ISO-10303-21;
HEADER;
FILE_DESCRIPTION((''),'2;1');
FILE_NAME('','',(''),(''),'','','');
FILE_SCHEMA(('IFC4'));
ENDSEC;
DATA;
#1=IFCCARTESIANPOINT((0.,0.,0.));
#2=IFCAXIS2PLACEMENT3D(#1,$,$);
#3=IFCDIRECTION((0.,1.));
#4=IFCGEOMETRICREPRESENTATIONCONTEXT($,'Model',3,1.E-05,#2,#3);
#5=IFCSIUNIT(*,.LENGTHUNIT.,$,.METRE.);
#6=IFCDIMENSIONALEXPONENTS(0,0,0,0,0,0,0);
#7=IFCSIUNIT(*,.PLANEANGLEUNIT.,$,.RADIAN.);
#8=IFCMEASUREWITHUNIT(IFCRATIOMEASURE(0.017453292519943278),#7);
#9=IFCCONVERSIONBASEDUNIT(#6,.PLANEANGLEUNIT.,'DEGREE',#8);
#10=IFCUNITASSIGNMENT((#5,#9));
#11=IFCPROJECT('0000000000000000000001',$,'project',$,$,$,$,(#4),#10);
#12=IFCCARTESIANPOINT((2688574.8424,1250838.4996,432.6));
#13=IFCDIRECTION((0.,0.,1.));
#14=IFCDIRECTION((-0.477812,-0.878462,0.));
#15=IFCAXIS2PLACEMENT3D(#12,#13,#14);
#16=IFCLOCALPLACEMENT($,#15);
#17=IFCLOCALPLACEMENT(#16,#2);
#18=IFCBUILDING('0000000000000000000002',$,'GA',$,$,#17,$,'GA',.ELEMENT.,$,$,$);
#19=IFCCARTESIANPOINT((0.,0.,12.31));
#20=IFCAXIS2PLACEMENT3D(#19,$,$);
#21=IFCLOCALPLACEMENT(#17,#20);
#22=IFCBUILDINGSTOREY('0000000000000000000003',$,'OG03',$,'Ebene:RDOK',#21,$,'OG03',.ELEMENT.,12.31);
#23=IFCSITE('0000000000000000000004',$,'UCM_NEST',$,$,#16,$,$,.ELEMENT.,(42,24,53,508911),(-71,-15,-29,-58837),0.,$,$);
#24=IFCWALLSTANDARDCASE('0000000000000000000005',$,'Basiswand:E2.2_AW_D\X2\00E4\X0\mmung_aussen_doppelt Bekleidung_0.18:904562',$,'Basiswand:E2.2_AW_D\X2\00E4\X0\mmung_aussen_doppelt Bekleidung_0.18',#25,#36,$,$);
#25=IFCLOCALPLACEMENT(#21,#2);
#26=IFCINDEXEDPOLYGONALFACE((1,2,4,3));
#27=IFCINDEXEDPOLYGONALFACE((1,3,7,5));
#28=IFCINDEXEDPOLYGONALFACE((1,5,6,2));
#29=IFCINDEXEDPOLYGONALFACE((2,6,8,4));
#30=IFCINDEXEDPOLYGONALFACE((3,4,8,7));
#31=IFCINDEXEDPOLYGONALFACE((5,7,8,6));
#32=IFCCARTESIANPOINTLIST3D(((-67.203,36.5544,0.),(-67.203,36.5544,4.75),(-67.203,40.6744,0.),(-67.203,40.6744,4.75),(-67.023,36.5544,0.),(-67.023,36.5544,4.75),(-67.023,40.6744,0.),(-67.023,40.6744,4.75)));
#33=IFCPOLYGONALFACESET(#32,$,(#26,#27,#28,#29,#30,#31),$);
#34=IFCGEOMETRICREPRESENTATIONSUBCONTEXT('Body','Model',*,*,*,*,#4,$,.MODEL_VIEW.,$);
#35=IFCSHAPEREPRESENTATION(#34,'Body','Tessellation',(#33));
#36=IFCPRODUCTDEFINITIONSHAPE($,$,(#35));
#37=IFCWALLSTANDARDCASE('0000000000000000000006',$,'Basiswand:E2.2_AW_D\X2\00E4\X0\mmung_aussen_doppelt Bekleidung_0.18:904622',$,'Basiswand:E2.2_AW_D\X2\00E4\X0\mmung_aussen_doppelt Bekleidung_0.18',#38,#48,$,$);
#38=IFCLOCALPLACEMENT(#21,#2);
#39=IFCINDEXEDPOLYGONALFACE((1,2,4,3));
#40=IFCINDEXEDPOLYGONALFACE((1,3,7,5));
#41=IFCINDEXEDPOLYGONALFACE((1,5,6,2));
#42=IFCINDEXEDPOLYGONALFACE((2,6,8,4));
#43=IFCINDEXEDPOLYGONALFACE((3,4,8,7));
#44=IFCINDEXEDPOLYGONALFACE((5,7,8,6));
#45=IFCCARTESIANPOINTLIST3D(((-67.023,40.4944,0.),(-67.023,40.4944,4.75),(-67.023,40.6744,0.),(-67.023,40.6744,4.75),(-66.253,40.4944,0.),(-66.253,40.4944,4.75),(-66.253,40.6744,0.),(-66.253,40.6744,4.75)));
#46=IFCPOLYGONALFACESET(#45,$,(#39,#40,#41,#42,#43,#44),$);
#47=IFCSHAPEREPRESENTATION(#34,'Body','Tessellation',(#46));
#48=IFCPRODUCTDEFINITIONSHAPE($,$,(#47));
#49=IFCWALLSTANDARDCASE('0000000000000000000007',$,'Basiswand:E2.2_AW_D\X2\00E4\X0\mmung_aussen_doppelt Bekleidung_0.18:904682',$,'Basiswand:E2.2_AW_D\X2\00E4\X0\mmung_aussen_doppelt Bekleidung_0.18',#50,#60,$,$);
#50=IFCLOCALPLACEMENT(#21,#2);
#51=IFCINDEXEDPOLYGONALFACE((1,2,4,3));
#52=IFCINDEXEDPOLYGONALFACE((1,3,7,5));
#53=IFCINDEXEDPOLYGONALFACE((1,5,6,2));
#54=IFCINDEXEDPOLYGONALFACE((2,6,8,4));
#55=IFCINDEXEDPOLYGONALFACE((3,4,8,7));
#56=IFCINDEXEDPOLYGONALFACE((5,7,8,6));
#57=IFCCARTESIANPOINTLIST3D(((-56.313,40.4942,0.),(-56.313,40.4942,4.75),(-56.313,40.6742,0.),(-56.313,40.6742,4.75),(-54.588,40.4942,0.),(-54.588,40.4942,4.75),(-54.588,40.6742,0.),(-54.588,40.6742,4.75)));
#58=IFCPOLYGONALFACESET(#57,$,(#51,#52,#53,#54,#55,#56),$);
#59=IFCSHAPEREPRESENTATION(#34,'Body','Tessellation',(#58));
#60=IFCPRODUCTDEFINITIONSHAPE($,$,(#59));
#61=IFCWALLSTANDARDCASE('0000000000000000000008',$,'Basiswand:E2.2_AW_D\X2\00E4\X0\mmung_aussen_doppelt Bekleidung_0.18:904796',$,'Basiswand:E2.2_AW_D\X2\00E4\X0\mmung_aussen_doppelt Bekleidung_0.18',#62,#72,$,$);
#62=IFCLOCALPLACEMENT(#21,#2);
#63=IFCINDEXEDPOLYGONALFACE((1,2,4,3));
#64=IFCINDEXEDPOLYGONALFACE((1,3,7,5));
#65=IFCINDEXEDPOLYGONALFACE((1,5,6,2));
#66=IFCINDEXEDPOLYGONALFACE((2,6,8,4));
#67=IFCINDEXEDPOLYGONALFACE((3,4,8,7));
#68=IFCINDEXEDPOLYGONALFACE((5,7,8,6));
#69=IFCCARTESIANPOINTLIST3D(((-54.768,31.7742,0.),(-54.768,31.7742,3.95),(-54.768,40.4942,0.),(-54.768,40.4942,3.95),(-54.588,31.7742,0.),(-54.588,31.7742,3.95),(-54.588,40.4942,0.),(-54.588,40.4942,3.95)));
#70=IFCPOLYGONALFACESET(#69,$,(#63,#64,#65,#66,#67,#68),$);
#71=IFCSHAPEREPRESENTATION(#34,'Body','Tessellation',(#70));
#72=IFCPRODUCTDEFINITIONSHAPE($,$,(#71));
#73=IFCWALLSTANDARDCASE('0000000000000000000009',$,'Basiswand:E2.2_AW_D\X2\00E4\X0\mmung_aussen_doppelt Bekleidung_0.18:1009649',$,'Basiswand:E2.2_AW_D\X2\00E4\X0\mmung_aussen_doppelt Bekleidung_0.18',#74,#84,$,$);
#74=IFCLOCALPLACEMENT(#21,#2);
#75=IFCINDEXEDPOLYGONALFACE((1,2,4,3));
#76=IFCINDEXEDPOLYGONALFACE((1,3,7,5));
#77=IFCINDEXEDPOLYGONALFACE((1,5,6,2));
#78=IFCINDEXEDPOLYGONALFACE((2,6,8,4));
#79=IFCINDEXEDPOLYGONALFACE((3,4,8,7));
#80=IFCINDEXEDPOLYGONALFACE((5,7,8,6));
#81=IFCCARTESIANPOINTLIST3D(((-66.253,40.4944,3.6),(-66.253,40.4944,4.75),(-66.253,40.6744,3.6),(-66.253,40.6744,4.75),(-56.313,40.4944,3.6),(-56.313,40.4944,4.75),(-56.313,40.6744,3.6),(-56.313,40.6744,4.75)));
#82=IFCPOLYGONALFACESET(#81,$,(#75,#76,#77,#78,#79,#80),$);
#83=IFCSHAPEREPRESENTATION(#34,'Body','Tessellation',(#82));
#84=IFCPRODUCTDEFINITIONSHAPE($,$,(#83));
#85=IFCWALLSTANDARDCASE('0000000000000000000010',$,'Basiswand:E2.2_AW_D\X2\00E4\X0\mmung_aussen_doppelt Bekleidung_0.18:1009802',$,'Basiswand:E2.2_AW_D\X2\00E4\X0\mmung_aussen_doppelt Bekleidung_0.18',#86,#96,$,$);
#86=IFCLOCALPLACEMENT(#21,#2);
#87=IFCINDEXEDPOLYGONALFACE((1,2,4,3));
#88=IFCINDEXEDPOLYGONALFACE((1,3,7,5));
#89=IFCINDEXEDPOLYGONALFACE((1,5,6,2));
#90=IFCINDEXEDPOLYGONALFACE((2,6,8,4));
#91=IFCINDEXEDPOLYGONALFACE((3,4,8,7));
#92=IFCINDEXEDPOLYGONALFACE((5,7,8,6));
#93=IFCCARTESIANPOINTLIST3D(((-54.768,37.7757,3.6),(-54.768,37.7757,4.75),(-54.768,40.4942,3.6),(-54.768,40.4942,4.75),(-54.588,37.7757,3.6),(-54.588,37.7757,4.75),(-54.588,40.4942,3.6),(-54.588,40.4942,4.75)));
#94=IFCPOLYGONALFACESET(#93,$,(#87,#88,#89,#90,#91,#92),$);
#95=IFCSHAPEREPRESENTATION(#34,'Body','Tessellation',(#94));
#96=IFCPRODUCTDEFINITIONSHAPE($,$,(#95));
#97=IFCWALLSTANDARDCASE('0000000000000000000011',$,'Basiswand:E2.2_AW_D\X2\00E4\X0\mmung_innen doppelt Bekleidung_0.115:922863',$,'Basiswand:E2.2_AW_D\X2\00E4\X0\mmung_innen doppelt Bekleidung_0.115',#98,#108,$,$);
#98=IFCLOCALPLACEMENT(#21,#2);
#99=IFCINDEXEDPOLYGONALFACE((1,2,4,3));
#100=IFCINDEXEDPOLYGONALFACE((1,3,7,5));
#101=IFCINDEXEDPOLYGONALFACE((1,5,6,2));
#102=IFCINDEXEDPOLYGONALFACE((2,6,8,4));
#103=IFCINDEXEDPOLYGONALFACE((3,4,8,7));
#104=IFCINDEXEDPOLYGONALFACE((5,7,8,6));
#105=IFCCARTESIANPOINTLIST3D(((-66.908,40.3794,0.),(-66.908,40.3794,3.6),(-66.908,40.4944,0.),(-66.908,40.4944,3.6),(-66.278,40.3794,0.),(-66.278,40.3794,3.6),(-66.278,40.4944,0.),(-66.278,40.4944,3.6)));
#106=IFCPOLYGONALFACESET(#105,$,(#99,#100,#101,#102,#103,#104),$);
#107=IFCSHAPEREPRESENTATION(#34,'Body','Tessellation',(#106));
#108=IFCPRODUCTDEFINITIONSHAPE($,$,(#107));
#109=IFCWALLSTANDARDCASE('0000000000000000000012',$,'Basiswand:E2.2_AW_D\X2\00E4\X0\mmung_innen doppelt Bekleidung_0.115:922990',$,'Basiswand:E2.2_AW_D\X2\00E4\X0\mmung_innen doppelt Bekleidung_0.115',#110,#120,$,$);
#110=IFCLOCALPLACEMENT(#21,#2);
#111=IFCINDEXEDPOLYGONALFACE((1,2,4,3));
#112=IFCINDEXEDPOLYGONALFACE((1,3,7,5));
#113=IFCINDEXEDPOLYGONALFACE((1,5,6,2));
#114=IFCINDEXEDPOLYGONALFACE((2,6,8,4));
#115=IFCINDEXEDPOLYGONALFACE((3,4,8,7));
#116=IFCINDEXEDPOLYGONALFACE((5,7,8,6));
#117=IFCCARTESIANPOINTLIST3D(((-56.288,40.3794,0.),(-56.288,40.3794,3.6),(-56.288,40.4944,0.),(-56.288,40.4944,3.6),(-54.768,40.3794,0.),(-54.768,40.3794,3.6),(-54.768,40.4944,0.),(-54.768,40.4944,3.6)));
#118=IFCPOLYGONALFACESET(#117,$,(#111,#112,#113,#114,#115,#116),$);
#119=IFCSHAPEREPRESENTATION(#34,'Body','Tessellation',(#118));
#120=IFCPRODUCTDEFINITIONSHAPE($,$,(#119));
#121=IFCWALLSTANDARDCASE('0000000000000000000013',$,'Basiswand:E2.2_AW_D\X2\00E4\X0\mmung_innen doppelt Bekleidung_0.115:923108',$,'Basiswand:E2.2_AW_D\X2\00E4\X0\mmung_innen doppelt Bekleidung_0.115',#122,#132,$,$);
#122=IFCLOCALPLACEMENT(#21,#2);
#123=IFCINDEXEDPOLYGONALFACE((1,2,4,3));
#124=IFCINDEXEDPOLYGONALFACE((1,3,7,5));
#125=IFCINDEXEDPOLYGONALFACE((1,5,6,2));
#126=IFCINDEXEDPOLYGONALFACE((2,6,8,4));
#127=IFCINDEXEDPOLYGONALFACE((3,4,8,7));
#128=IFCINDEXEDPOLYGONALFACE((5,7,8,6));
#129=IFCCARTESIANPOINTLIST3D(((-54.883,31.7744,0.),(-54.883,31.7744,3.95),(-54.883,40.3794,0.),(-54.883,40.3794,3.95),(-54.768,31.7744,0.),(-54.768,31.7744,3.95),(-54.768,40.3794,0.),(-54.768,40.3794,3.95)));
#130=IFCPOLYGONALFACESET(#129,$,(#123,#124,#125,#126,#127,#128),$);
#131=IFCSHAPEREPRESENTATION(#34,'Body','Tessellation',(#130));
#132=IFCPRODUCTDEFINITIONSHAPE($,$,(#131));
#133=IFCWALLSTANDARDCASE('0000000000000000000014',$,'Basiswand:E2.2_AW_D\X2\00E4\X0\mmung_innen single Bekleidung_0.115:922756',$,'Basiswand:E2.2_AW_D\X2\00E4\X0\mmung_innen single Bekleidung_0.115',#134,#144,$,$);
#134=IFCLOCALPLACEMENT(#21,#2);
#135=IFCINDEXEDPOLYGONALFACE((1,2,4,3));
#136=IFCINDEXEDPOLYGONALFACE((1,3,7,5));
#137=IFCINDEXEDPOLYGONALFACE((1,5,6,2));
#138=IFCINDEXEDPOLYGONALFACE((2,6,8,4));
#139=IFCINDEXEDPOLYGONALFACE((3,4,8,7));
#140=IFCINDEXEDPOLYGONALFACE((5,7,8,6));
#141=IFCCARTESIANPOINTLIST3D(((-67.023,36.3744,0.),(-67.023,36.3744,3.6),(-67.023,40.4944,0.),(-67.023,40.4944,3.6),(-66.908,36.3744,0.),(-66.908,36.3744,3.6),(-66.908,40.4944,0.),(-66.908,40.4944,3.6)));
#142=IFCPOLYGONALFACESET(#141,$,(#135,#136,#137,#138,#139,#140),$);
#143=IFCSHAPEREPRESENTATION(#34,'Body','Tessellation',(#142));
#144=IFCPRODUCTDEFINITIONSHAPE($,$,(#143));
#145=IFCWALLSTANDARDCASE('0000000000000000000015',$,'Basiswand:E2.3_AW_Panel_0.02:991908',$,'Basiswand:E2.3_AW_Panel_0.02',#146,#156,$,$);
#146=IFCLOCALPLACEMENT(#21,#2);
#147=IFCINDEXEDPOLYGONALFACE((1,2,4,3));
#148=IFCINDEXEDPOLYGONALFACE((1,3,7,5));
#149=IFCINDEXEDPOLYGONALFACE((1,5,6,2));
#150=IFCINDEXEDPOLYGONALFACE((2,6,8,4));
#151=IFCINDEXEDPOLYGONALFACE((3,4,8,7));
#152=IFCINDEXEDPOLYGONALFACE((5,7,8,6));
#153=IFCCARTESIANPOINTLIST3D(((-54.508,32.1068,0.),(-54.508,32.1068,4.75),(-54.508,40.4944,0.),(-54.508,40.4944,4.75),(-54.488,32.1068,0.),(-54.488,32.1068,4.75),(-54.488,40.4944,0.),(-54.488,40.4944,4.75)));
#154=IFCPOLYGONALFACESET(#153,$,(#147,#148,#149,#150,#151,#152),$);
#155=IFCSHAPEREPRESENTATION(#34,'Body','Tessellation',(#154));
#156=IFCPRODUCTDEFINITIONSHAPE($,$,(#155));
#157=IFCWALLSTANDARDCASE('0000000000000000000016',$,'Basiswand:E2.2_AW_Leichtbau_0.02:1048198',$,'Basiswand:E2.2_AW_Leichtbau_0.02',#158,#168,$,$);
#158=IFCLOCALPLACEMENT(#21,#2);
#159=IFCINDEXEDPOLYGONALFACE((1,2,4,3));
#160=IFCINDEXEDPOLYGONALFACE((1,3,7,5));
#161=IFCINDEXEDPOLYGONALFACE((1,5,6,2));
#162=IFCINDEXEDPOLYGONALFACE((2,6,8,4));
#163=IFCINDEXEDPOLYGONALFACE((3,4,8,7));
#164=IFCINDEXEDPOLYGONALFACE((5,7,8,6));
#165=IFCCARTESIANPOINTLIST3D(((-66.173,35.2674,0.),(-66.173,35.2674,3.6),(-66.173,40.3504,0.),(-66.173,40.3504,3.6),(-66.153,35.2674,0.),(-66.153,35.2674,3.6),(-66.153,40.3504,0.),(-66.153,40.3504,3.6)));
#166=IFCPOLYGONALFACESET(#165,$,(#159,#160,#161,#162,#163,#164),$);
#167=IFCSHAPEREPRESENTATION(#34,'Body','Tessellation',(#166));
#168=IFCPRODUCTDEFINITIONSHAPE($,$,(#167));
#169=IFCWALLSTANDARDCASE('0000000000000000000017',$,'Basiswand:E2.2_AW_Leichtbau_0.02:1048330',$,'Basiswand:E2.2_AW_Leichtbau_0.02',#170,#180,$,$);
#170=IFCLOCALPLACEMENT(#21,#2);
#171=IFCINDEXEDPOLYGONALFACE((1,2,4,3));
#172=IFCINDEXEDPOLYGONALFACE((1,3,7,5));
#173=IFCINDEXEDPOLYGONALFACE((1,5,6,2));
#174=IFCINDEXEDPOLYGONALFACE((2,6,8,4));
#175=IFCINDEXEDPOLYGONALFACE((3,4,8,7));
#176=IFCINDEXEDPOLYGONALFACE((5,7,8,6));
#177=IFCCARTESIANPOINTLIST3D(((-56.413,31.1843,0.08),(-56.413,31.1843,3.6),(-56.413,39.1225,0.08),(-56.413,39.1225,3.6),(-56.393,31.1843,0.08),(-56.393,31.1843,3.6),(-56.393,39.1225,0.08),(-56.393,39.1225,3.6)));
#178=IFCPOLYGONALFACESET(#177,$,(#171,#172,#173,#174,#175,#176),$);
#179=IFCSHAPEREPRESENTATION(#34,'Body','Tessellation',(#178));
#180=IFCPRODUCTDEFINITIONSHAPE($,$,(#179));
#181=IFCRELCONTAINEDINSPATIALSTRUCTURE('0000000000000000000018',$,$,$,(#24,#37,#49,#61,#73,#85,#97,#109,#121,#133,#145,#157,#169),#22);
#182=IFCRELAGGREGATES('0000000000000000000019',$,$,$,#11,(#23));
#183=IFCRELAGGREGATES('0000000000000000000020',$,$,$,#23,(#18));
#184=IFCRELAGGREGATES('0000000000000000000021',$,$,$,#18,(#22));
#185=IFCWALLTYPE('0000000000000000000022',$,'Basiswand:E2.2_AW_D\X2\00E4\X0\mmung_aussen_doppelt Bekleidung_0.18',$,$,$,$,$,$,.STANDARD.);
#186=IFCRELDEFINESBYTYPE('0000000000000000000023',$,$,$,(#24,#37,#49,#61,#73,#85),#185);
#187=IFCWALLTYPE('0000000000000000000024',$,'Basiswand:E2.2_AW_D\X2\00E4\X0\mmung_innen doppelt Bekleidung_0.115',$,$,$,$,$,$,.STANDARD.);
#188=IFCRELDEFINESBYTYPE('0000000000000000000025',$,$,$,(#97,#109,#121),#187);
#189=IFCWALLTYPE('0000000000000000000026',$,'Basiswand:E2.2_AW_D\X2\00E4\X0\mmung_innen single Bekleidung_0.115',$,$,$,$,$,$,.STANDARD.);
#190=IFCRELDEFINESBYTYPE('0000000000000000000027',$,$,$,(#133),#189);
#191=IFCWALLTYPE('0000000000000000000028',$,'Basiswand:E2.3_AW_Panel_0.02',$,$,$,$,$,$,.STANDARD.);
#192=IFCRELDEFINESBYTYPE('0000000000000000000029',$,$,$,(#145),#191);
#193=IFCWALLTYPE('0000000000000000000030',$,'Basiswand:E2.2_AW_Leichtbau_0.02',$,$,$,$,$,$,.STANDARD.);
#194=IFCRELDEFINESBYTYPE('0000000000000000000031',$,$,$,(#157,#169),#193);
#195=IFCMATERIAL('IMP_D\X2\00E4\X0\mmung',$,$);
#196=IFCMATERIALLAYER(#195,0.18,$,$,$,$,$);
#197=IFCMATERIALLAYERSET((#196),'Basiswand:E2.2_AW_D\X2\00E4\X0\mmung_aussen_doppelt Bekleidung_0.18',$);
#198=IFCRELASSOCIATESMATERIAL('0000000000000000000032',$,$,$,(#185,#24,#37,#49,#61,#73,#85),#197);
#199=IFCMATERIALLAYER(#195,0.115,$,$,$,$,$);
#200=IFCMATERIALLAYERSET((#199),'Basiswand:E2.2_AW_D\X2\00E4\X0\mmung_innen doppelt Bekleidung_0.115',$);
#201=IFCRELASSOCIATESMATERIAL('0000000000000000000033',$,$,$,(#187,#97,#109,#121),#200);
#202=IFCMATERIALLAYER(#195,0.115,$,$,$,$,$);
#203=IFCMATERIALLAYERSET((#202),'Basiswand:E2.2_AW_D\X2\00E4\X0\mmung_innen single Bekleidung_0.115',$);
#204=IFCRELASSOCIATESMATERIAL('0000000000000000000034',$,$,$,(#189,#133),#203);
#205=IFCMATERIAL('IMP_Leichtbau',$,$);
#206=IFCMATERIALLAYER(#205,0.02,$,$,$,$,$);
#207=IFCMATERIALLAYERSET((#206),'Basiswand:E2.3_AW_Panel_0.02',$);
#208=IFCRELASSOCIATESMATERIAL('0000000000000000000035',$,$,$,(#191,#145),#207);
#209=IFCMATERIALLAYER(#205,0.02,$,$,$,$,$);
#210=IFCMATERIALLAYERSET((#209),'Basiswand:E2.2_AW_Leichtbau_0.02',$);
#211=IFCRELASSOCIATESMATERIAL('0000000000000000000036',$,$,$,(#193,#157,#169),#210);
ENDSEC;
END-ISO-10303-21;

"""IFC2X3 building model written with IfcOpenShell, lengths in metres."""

from ifc_helpers import new_model, entity, si_unit, converted_unit, direction, frame, frame_2d, origin, place, context, subcontext, project, spatial, polyline, rectangle, extrude, clip, bounded_halfspace, material, layer, layer_set, layer_usage, type_object, element, save


model = new_model("IFC2X3")

# Units and contexts
model_context = context("Model", 3, precision=1e-05, world=origin(), true_north=direction((0.0, 1.0)))
body_context = subcontext(model_context, "Body", "Model", "MODEL_VIEW")
ifc_project = project(units=[si_unit("LENGTHUNIT", "METRE"), converted_unit("PLANEANGLEUNIT", "DEGREE", entity("IfcRatioMeasure", 0.017453292519943278), si_unit("PLANEANGLEUNIT", "RADIAN"), dimensions=[0, 0, 0, 0, 0, 0, 0])], contexts=[model_context])

# Site, building, storey
site_placement = place(None, frame((2688574.8424, 1250838.4996, 432.6), z_axis=(0.0, 0.0, 1.0), x_axis=(-0.477812, -0.878462, 0.0)))
site = spatial("IfcSite", under=ifc_project, at=site_placement, Name="UCM_NEST", CompositionType="ELEMENT", RefLatitude=(42, 24, 53, 508911), RefLongitude=(-71, -15, -29, -58837), RefElevation=0.0)
building_placement = place(site_placement, origin())
building = spatial("IfcBuilding", under=site, at=building_placement, Name="GA", LongName="GA", CompositionType="ELEMENT")
storey_placement = place(building_placement, frame((0.0, 0.0, 12.31)))
storey = spatial("IfcBuildingStorey", under=building, at=storey_placement, Name="OG03", ObjectType="Ebene:RDOK", LongName="OG03", CompositionType="ELEMENT", Elevation=12.31)

# Walls
ifc_material_1 = material(Name="IMP_Dämmung")
ifc_layer_1 = layer(ifc_material_1, 0.18)
ifc_layer_set_1 = layer_set([ifc_layer_1], Name="Basiswand:E2.2_AW_Dämmung_aussen_doppelt Bekleidung_0.18")
ifc_layer_usage_1 = layer_usage(ifc_layer_set_1, "AXIS2", "NEGATIVE", 0.09)
wall_type_1 = type_object("IfcWallType", Name="Basiswand:E2.2_AW_Dämmung_aussen_doppelt Bekleidung_0.18", PredefinedType="STANDARD", material=ifc_layer_set_1)
wall_1_placement = place(storey_placement, frame((-67.113, 36.5544, 0.0), z_axis=(0.0, 0.0, 1.0), x_axis=(0.0, 1.0, 0.0)))
element("IfcWallStandardCase", 1, at=wall_1_placement, inside=storey, type_object=wall_type_1, material=ifc_layer_usage_1, Name="Basiswand:E2.2_AW_Dämmung_aussen_doppelt Bekleidung_0.18:904562", ObjectType="Basiswand:E2.2_AW_Dämmung_aussen_doppelt Bekleidung_0.18", context=body_context, shape_type="SweptSolid", body=[
    extrude(rectangle(XDim=4.12, YDim=0.18, at=frame_2d((2.06, 0.0), x_axis=(-1.0, 0.0))), origin(), (0.0, 0.0, 1.0), 4.75),
])
wall_2_placement = place(storey_placement, frame((-67.023, 40.5844, 0.0)))
element("IfcWallStandardCase", 2, at=wall_2_placement, inside=storey, type_object=wall_type_1, material=ifc_layer_usage_1, Name="Basiswand:E2.2_AW_Dämmung_aussen_doppelt Bekleidung_0.18:904622", ObjectType="Basiswand:E2.2_AW_Dämmung_aussen_doppelt Bekleidung_0.18", context=body_context, shape_type="SweptSolid", body=[
    extrude(rectangle(XDim=0.77, YDim=0.18, at=frame_2d((0.385, 0.0), x_axis=(-1.0, 0.0))), origin(), (0.0, 0.0, 1.0), 4.75),
])
wall_3_placement = place(storey_placement, frame((-56.313, 40.5842, 0.0)))
element("IfcWallStandardCase", 3, at=wall_3_placement, inside=storey, type_object=wall_type_1, material=ifc_layer_usage_1, Name="Basiswand:E2.2_AW_Dämmung_aussen_doppelt Bekleidung_0.18:904682", ObjectType="Basiswand:E2.2_AW_Dämmung_aussen_doppelt Bekleidung_0.18", context=body_context, shape_type="SweptSolid", body=[
    extrude(rectangle(XDim=1.725, YDim=0.18, at=frame_2d((0.8625, 0.0), x_axis=(-1.0, 0.0))), origin(), (0.0, 0.0, 1.0), 4.75),
])
wall_4_placement = place(storey_placement, frame((-54.678, 40.4942, 0.0), z_axis=(0.0, 0.0, 1.0), x_axis=(0.0, -1.0, 0.0)))
element("IfcWallStandardCase", 4, at=wall_4_placement, inside=storey, type_object=wall_type_1, material=ifc_layer_usage_1, Name="Basiswand:E2.2_AW_Dämmung_aussen_doppelt Bekleidung_0.18:904796", ObjectType="Basiswand:E2.2_AW_Dämmung_aussen_doppelt Bekleidung_0.18", context=body_context, shape_type="SweptSolid", body=[
    extrude(rectangle(XDim=8.72, YDim=0.18, at=frame_2d((4.36, 0.0), x_axis=(-1.0, 0.0))), origin(), (0.0, 0.0, 1.0), 3.95),
])
wall_5_placement = place(storey_placement, frame((-66.253, 40.5844, 3.6)))
element("IfcWallStandardCase", 5, at=wall_5_placement, inside=storey, type_object=wall_type_1, material=ifc_layer_usage_1, Name="Basiswand:E2.2_AW_Dämmung_aussen_doppelt Bekleidung_0.18:1009649", ObjectType="Basiswand:E2.2_AW_Dämmung_aussen_doppelt Bekleidung_0.18", context=body_context, shape_type="SweptSolid", body=[
    extrude(rectangle(XDim=9.94, YDim=0.18, at=frame_2d((4.97, 0.0), x_axis=(-1.0, 0.0))), origin(), (0.0, 0.0, 1.0), 1.15),
])
wall_6_placement = place(storey_placement, frame((-54.678, 37.7757, 3.6), z_axis=(0.0, 0.0, 1.0), x_axis=(0.0, 1.0, 0.0)))
element("IfcWallStandardCase", 6, at=wall_6_placement, inside=storey, type_object=wall_type_1, material=ifc_layer_usage_1, Name="Basiswand:E2.2_AW_Dämmung_aussen_doppelt Bekleidung_0.18:1009802", ObjectType="Basiswand:E2.2_AW_Dämmung_aussen_doppelt Bekleidung_0.18", context=body_context, shape_type="SweptSolid", body=[
    extrude(rectangle(XDim=2.7185, YDim=0.18, at=frame_2d((1.3592, 0.0), x_axis=(-1.0, 0.0))), origin(), (0.0, 0.0, 1.0), 1.15),
])
ifc_layer_2 = layer(ifc_material_1, 0.115)
ifc_layer_set_2 = layer_set([ifc_layer_2], Name="Basiswand:E2.2_AW_Dämmung_innen doppelt Bekleidung_0.115")
ifc_layer_usage_2 = layer_usage(ifc_layer_set_2, "AXIS2", "NEGATIVE", 0.0575)
wall_type_2 = type_object("IfcWallType", Name="Basiswand:E2.2_AW_Dämmung_innen doppelt Bekleidung_0.115", PredefinedType="STANDARD", material=ifc_layer_set_2)
wall_7_placement = place(storey_placement, frame((-66.908, 40.4369, 0.0)))
element("IfcWallStandardCase", 7, at=wall_7_placement, inside=storey, type_object=wall_type_2, material=ifc_layer_usage_2, Name="Basiswand:E2.2_AW_Dämmung_innen doppelt Bekleidung_0.115:922863", ObjectType="Basiswand:E2.2_AW_Dämmung_innen doppelt Bekleidung_0.115", context=body_context, shape_type="SweptSolid", body=[
    extrude(rectangle(XDim=0.63, YDim=0.115, at=frame_2d((0.315, 0.0), x_axis=(-1.0, 0.0))), origin(), (0.0, 0.0, 1.0), 3.6),
])
wall_8_placement = place(storey_placement, frame((-56.288, 40.4369, 0.0)))
element("IfcWallStandardCase", 8, at=wall_8_placement, inside=storey, type_object=wall_type_2, material=ifc_layer_usage_2, Name="Basiswand:E2.2_AW_Dämmung_innen doppelt Bekleidung_0.115:922990", ObjectType="Basiswand:E2.2_AW_Dämmung_innen doppelt Bekleidung_0.115", context=body_context, shape_type="SweptSolid", body=[
    extrude(rectangle(XDim=1.52, YDim=0.115, at=frame_2d((0.76, 0.0), x_axis=(-1.0, 0.0))), origin(), (0.0, 0.0, 1.0), 3.6),
])
wall_9_placement = place(storey_placement, frame((-54.8255, 40.3794, 0.0), z_axis=(0.0, 0.0, 1.0), x_axis=(0.0, -1.0, 0.0)))
element("IfcWallStandardCase", 9, at=wall_9_placement, inside=storey, type_object=wall_type_2, material=ifc_layer_usage_2, Name="Basiswand:E2.2_AW_Dämmung_innen doppelt Bekleidung_0.115:923108", ObjectType="Basiswand:E2.2_AW_Dämmung_innen doppelt Bekleidung_0.115", context=body_context, shape_type="SweptSolid", body=[
    extrude(rectangle(XDim=8.605, YDim=0.115, at=frame_2d((4.3025, 0.0), x_axis=(-1.0, 0.0))), origin(), (0.0, 0.0, 1.0), 3.95),
])
ifc_layer_3 = layer(ifc_material_1, 0.115)
ifc_layer_set_3 = layer_set([ifc_layer_3], Name="Basiswand:E2.2_AW_Dämmung_innen single Bekleidung_0.115")
ifc_layer_usage_3 = layer_usage(ifc_layer_set_3, "AXIS2", "NEGATIVE", 0.0575)
wall_type_3 = type_object("IfcWallType", Name="Basiswand:E2.2_AW_Dämmung_innen single Bekleidung_0.115", PredefinedType="STANDARD", material=ifc_layer_set_3)
wall_10_placement = place(storey_placement, frame((-66.9655, 36.3744, 0.0), z_axis=(0.0, 0.0, 1.0), x_axis=(0.0, 1.0, 0.0)))
element("IfcWallStandardCase", 10, at=wall_10_placement, inside=storey, type_object=wall_type_3, material=ifc_layer_usage_3, Name="Basiswand:E2.2_AW_Dämmung_innen single Bekleidung_0.115:922756", ObjectType="Basiswand:E2.2_AW_Dämmung_innen single Bekleidung_0.115", context=body_context, shape_type="SweptSolid", body=[
    extrude(rectangle(XDim=4.12, YDim=0.115, at=frame_2d((2.06, 0.0), x_axis=(-1.0, 0.0))), origin(), (0.0, 0.0, 1.0), 3.6),
])

# Walls
ifc_material_2 = material(Name="IMP_Leichtbau")
ifc_layer_4 = layer(ifc_material_2, 0.02)
ifc_layer_set_4 = layer_set([ifc_layer_4], Name="Basiswand:E2.3_AW_Panel_0.02")
ifc_layer_usage_4 = layer_usage(ifc_layer_set_4, "AXIS2", "NEGATIVE", 0.01)
wall_type_4 = type_object("IfcWallType", Name="Basiswand:E2.3_AW_Panel_0.02", PredefinedType="STANDARD", material=ifc_layer_set_4)
wall_11_placement = place(storey_placement, frame((-54.498, 40.4944, 0.0), z_axis=(0.0, 0.0, 1.0), x_axis=(0.0, -1.0, 0.0)))
element("IfcWallStandardCase", 11, at=wall_11_placement, inside=storey, type_object=wall_type_4, material=ifc_layer_usage_4, Name="Basiswand:E2.3_AW_Panel_0.02:991908", ObjectType="Basiswand:E2.3_AW_Panel_0.02", context=body_context, shape_type="SweptSolid", body=[
    extrude(rectangle(XDim=8.3877, YDim=0.02, at=frame_2d((4.1938, 0.0), x_axis=(-1.0, 0.0))), origin(), (0.0, 0.0, 1.0), 4.75),
])
ifc_layer_5 = layer(ifc_material_2, 0.02)
ifc_layer_set_5 = layer_set([ifc_layer_5], Name="Basiswand:E2.2_AW_Leichtbau_0.02")
ifc_layer_usage_5 = layer_usage(ifc_layer_set_5, "AXIS2", "NEGATIVE", 0.01)
wall_type_5 = type_object("IfcWallType", Name="Basiswand:E2.2_AW_Leichtbau_0.02", PredefinedType="STANDARD", material=ifc_layer_set_5)
wall_12_placement = place(storey_placement, frame((-66.163, 35.2674, 0.0), z_axis=(0.0, 0.0, 1.0), x_axis=(0.0, 1.0, 0.0)))
element("IfcWallStandardCase", 12, at=wall_12_placement, inside=storey, type_object=wall_type_5, material=ifc_layer_usage_5, Name="Basiswand:E2.2_AW_Leichtbau_0.02:1048198", ObjectType="Basiswand:E2.2_AW_Leichtbau_0.02", context=body_context, shape_type="SweptSolid", body=[
    extrude(rectangle(XDim=5.083, YDim=0.02, at=frame_2d((2.5415, 0.0), x_axis=(-1.0, 0.0))), origin(), (0.0, 0.0, 1.0), 3.6),
])
wall_13_placement = place(storey_placement, frame((-56.403, 31.1843, 0.08), z_axis=(0.0, 0.0, 1.0), x_axis=(0.0, 1.0, 0.0)))
element("IfcWallStandardCase", 13, at=wall_13_placement, inside=storey, type_object=wall_type_5, material=ifc_layer_usage_5, Name="Basiswand:E2.2_AW_Leichtbau_0.02:1048330", ObjectType="Basiswand:E2.2_AW_Leichtbau_0.02", context=body_context, shape_type="Clipping", body=[
    clip(extrude(rectangle(XDim=7.9382, YDim=0.02, at=frame_2d((3.9691, 0.0), x_axis=(-1.0, 0.0))), origin(), (0.0, 0.0, 1.0), 3.52), bounded_halfspace(frame((7.9382, -0.01, 0.0), z_axis=(0.0, 0.0, 1.0), x_axis=(0.0, 1.0, 0.0)), True, frame((7.9382, -0.01, 0.0), z_axis=(0.0, 0.0, 1.0), x_axis=(0.0, 1.0, 0.0)), polyline([(0.0, 0.0), (0.02, 0.0), (0.02, 7.9382), (0.0, 7.9382), (0.0, 0.0)]))),
])

save(model, "model.ifc")
